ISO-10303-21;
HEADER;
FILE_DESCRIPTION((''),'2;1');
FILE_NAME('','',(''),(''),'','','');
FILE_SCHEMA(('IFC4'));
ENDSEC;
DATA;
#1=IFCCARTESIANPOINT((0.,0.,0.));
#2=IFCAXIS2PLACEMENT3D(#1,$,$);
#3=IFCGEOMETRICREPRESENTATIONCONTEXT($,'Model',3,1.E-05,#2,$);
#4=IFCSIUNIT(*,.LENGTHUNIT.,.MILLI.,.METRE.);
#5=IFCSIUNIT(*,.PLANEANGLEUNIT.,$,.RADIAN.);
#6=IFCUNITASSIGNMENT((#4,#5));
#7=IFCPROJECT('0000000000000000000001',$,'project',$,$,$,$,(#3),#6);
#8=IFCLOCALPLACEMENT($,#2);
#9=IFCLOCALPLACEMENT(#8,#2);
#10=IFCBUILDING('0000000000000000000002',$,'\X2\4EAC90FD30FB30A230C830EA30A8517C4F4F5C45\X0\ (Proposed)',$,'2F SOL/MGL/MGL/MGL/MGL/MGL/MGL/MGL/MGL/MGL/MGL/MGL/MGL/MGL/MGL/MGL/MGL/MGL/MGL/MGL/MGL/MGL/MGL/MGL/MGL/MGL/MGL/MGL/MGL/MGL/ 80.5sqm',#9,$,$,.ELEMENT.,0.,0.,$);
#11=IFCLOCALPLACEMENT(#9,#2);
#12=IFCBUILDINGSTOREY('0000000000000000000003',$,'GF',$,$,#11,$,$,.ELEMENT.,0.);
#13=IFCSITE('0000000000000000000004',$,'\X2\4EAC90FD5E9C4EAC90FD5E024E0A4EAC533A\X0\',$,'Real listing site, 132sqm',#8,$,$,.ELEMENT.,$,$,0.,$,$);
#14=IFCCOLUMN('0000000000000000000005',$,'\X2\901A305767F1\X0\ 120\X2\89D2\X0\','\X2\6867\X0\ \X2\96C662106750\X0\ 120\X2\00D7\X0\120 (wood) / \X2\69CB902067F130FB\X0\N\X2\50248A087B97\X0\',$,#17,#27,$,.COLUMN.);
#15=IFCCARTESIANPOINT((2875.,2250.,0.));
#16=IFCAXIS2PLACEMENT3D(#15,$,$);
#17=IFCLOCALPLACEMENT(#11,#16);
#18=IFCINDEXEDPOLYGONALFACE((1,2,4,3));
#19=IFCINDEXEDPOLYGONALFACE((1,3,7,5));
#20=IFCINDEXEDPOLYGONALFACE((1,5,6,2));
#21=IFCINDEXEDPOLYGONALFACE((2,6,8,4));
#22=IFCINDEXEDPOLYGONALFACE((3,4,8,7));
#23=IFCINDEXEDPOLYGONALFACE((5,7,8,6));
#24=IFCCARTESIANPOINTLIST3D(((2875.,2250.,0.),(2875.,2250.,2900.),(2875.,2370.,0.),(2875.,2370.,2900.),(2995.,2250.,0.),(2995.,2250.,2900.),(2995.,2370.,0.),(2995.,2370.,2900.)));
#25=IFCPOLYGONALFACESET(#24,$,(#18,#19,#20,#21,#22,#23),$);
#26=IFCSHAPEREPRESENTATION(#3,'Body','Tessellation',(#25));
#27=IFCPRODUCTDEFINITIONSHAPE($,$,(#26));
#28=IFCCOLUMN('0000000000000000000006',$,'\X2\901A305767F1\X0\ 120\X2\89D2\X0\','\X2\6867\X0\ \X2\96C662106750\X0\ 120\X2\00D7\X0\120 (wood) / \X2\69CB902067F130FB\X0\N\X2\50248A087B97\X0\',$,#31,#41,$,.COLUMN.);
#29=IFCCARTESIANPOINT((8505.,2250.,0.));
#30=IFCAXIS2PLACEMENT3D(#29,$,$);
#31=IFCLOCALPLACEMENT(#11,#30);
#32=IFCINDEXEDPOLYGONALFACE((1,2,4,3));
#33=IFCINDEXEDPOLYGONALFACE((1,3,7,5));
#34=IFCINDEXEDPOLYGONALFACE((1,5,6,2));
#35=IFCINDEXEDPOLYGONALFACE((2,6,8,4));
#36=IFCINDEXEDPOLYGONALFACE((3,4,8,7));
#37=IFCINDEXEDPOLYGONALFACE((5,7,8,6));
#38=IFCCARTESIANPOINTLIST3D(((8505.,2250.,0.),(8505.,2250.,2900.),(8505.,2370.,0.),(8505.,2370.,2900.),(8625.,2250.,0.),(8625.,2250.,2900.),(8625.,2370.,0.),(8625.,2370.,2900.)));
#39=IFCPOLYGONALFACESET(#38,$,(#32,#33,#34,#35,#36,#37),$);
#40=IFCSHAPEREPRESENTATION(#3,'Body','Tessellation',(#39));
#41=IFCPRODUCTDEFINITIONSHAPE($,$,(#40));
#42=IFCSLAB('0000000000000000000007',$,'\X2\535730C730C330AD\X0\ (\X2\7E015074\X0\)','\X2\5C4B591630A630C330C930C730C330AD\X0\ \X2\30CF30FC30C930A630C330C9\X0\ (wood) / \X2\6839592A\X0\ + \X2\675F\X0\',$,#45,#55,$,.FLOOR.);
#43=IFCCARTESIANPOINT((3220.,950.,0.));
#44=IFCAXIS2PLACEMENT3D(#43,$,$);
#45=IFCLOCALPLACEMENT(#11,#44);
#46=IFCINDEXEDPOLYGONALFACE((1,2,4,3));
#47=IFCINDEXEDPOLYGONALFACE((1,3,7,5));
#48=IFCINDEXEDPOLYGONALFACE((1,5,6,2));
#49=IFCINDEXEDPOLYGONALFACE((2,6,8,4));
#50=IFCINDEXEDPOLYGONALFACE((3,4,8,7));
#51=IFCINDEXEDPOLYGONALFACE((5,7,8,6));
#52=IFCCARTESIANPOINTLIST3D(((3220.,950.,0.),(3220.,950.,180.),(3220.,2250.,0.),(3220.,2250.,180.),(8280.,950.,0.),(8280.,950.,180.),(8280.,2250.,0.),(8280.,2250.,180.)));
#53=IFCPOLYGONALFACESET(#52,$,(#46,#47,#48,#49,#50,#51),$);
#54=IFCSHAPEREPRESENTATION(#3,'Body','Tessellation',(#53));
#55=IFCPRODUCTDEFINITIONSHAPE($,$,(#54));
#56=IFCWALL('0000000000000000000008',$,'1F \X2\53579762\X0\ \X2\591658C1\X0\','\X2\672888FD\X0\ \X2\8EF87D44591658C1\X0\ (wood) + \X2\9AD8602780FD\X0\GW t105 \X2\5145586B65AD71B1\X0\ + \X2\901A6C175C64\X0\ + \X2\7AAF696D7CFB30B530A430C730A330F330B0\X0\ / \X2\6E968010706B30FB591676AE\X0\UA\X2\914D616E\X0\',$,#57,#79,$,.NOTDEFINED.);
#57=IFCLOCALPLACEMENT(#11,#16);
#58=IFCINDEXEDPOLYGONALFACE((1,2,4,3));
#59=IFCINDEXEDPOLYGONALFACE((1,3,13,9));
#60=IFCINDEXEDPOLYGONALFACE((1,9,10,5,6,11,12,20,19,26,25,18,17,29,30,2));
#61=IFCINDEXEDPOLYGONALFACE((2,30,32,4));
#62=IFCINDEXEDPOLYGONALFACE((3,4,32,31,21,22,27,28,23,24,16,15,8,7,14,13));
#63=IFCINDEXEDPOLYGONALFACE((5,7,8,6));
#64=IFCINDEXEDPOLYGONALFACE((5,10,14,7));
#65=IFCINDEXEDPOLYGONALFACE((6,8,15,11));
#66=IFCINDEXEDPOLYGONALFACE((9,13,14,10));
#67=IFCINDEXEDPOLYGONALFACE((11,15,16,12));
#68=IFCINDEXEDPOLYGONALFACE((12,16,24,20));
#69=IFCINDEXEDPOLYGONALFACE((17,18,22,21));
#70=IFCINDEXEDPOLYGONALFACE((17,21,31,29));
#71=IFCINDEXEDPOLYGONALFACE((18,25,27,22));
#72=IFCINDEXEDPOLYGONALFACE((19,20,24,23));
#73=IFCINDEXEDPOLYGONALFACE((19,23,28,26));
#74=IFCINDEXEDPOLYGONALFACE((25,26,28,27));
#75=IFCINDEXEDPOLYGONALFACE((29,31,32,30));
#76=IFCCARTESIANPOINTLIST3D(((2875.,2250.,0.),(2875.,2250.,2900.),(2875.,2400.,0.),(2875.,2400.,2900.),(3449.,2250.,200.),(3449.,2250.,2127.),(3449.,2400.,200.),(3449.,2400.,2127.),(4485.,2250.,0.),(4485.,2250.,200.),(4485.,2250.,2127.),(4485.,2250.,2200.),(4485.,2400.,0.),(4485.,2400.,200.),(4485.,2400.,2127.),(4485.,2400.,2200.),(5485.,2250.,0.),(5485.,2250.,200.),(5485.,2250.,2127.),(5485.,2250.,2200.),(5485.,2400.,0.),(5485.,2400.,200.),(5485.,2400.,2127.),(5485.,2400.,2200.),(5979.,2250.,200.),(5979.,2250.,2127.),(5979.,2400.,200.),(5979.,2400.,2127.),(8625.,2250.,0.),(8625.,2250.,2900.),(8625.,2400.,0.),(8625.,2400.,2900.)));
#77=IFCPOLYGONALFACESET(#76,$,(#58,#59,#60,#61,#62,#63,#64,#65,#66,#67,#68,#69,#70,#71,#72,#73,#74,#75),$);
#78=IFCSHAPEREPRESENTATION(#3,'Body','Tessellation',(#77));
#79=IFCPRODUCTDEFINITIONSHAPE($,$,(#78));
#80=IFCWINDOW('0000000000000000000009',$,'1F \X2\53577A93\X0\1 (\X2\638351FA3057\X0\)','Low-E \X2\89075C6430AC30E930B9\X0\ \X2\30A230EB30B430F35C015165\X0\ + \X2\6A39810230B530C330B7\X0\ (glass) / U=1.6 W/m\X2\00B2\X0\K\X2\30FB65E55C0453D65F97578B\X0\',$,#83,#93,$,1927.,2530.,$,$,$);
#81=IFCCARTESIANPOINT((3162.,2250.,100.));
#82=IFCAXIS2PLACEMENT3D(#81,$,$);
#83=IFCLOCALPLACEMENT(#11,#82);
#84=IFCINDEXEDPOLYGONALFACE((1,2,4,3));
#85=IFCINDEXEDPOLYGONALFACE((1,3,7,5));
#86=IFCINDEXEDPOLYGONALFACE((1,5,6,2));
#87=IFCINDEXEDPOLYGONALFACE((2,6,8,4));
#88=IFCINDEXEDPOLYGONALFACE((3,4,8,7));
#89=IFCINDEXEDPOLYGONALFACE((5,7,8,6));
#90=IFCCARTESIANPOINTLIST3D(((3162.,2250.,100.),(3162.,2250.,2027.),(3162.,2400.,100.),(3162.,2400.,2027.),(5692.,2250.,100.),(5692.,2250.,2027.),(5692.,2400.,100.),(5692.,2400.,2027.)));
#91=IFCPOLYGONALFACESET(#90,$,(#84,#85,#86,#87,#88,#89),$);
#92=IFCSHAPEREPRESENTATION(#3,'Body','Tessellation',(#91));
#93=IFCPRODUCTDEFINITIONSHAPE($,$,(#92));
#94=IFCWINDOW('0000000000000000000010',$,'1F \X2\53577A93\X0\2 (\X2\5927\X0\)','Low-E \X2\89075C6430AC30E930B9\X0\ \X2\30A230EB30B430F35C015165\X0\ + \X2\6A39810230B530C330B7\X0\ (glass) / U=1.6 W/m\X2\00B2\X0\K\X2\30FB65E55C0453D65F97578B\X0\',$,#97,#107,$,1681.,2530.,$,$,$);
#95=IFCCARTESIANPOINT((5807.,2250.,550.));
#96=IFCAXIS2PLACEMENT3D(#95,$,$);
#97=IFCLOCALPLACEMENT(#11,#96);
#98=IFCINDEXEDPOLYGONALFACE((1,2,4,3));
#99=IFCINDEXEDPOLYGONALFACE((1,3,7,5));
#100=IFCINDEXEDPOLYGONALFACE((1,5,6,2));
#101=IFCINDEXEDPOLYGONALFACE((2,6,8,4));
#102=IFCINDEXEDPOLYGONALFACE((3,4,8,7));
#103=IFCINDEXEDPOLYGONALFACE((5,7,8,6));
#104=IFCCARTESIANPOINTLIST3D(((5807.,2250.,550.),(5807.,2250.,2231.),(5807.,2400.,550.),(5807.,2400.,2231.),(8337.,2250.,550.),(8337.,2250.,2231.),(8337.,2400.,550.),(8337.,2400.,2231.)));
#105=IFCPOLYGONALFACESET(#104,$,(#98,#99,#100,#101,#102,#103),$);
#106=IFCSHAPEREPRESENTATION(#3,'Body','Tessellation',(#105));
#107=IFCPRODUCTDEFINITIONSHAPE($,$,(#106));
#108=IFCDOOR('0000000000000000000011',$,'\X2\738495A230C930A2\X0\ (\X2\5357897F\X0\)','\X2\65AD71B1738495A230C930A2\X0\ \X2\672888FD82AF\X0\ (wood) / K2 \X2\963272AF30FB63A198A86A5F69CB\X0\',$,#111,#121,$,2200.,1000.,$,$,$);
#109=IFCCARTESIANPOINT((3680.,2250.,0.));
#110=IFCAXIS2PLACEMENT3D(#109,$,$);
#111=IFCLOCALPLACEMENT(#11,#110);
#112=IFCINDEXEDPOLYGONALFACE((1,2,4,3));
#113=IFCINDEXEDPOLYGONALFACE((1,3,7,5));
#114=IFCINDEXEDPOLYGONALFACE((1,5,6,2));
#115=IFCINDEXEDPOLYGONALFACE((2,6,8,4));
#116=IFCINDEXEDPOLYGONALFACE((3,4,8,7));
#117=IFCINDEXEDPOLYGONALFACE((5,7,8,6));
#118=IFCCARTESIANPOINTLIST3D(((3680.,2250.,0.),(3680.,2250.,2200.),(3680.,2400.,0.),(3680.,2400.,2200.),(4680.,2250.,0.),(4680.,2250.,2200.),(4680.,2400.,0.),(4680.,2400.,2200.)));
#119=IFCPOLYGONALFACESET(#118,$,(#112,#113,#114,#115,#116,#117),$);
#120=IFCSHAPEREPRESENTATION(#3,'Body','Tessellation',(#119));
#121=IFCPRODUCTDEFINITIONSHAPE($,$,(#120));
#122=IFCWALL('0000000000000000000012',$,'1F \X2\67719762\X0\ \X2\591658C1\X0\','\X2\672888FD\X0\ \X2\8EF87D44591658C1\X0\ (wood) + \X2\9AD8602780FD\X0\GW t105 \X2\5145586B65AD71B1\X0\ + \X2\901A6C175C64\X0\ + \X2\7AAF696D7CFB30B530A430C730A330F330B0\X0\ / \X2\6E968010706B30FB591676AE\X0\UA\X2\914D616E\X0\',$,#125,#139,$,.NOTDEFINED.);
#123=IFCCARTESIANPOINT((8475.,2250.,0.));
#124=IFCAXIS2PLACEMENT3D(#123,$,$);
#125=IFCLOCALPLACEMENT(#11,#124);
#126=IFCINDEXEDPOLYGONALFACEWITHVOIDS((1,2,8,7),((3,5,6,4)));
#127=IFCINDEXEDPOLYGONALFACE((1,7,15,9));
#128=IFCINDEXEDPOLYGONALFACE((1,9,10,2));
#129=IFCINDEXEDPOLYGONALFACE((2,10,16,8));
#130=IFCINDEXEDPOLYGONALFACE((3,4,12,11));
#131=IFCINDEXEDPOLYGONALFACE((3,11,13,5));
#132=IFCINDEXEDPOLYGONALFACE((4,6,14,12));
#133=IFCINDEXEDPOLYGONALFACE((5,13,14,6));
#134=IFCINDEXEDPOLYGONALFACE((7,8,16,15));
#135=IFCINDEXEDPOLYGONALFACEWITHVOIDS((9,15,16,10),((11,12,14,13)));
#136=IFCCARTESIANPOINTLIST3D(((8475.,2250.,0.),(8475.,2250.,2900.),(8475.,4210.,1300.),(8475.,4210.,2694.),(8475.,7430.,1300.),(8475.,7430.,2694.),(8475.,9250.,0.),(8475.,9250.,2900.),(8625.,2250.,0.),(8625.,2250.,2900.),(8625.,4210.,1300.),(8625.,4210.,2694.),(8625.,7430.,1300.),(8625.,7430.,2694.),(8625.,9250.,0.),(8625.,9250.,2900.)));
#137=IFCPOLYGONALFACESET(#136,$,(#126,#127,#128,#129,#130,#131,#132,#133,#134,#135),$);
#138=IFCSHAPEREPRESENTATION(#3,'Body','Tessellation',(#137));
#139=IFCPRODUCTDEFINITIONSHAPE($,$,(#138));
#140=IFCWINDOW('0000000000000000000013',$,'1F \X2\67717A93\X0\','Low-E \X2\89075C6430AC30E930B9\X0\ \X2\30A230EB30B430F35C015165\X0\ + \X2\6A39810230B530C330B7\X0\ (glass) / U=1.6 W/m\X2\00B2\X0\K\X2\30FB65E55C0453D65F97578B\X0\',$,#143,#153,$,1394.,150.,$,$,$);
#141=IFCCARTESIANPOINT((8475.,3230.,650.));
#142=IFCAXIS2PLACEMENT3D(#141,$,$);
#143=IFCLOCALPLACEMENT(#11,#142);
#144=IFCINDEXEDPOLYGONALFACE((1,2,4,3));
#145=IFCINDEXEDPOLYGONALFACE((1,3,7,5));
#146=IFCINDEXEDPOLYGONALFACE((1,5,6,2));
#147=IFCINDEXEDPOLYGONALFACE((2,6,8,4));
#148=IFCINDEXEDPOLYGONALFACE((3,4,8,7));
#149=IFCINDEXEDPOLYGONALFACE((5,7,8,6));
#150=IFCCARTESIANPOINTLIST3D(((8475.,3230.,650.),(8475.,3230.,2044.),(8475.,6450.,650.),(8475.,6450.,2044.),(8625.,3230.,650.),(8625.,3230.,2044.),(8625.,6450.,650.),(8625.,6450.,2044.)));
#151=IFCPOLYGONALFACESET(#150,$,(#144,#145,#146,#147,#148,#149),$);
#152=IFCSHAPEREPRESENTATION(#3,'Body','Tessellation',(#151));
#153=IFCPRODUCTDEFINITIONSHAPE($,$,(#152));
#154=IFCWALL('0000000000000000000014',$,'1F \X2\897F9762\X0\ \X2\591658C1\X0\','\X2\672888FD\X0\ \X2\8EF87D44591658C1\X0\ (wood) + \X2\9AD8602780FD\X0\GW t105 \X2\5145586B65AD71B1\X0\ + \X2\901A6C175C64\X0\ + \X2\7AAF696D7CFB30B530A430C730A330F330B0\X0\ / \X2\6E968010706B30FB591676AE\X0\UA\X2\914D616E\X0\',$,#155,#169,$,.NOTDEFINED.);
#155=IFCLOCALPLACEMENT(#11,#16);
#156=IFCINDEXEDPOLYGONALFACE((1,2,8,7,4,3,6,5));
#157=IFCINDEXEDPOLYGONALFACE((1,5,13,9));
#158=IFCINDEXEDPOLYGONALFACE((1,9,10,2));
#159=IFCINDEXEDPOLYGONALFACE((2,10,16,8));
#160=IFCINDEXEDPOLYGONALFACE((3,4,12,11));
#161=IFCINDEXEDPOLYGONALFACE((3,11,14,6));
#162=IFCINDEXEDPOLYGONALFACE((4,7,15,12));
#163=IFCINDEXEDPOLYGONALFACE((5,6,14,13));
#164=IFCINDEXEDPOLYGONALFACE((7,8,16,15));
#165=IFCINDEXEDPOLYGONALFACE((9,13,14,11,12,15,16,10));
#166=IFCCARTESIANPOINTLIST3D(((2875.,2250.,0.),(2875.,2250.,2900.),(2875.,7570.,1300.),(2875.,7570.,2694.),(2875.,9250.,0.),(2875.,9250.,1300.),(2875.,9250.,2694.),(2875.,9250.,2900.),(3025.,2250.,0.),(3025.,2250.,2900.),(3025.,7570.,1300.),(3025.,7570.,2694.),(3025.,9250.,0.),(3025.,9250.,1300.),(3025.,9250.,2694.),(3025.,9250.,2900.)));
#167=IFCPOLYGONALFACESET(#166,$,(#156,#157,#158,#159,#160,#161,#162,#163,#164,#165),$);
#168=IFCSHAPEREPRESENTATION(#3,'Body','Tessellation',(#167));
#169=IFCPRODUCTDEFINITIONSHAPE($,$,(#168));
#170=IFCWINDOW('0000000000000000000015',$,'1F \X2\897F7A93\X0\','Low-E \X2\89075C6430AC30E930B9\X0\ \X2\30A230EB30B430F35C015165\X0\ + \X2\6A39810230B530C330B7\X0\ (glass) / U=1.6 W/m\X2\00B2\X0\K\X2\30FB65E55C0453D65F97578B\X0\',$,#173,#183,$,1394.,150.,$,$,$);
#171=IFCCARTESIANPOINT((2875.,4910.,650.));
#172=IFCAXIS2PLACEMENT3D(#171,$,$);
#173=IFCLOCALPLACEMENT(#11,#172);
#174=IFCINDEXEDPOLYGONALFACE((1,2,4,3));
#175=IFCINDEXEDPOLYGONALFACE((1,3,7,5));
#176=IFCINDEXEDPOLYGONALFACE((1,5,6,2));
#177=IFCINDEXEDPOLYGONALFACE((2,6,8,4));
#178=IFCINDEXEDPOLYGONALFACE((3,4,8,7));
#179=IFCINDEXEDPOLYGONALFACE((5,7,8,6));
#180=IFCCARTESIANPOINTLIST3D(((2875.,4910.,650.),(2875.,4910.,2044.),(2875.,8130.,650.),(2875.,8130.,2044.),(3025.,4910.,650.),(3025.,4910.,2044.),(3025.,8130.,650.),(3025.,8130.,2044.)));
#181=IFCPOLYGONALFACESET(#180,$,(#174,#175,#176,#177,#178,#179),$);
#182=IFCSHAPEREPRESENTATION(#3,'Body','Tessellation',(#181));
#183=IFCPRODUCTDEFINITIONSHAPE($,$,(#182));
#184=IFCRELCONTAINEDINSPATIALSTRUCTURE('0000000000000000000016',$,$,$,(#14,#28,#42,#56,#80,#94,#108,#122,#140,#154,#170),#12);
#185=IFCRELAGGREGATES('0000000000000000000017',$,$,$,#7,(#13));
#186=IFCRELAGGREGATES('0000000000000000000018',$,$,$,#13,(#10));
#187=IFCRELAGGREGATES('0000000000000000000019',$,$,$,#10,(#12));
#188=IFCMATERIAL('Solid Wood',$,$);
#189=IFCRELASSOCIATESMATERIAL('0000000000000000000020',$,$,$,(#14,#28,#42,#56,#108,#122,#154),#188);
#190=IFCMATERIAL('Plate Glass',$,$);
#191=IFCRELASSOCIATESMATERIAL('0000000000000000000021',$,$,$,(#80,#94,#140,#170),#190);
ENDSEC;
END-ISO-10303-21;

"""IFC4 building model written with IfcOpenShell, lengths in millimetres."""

from ifc_helpers import new_model, si_unit, frame, frame_2d, origin, place, context, project, spatial, rectangle, extrude, material, element, fill, save


model = new_model("IFC4")

# Units and contexts
model_context = context("Model", 3, precision=1e-05, world=origin())
ifc_project = project(units=[si_unit("LENGTHUNIT", "METRE", prefix="MILLI"), si_unit("PLANEANGLEUNIT", "RADIAN")], contexts=[model_context])

# Site, building, storey
site_placement = place(None, origin())
site = spatial("IfcSite", under=ifc_project, at=site_placement, Name="京都府京都市上京区", ObjectType="Real listing site, 132sqm", CompositionType="ELEMENT", RefElevation=0.0)
building_placement = place(site_placement, origin())
building = spatial("IfcBuilding", under=site, at=building_placement, Name="京都・アトリエ兼住居 (Proposed)", ObjectType="2F SOL/MGL/MGL/MGL/MGL/MGL/MGL/MGL/MGL/MGL/MGL/MGL/MGL/MGL/MGL/MGL/MGL/MGL/MGL/MGL/MGL/MGL/MGL/MGL/MGL/MGL/MGL/MGL/MGL/MGL/ 80.5sqm", CompositionType="ELEMENT", ElevationOfRefHeight=0.0, ElevationOfTerrain=0.0)
storey_placement = place(building_placement, origin())
storey = spatial("IfcBuildingStorey", under=building, at=storey_placement, Name="GF", CompositionType="ELEMENT", Elevation=0.0)

# Columns
ifc_material_1 = material(Name="Solid Wood")
column_1_placement = place(storey_placement, frame((2875.0, 2250.0, 0.0)))
element("IfcColumn", 1, at=column_1_placement, inside=storey, material=ifc_material_1, Name="通し柱 120角", Description="桧 集成材 120×120 (wood) / 構造柱・N値計算", PredefinedType="COLUMN", context=model_context, shape_type="SweptSolid", body=[
    extrude(rectangle(XDim=120.0, YDim=120.0, at=frame_2d((60.0, 60.0))), frame((2875.0, 2250.0, 0.0)), (0.0, 0.0, 1.0), 2900.0),
])
column_2_placement = place(storey_placement, frame((8505.0, 2250.0, 0.0)))
element("IfcColumn", 2, at=column_2_placement, inside=storey, material=ifc_material_1, Name="通し柱 120角", Description="桧 集成材 120×120 (wood) / 構造柱・N値計算", PredefinedType="COLUMN", context=model_context, shape_type="SweptSolid", body=[
    extrude(rectangle(XDim=120.0, YDim=120.0, at=frame_2d((60.0, 60.0))), frame((8505.0, 2250.0, 0.0)), (0.0, 0.0, 1.0), 2900.0),
])

# Slab
slab_1_placement = place(storey_placement, frame((3220.0, 950.0, 0.0)))
element("IfcSlab", 3, at=slab_1_placement, inside=storey, material=ifc_material_1, Name="南デッキ (縁側)", Description="屋外ウッドデッキ ハードウッド (wood) / 根太 + 束", PredefinedType="FLOOR", context=model_context, shape_type="SweptSolid", body=[
    extrude(rectangle(XDim=5060.0, YDim=1300.0, at=frame_2d((2530.0, 650.0))), frame((3220.0, 950.0, 0.0)), (0.0, 0.0, 1.0), 180.0),
])

# Wall, openings, windows, door
wall_1_placement = place(storey_placement, frame((2875.0, 2250.0, 0.0)))
wall_1 = element("IfcWall", 4, at=wall_1_placement, inside=storey, material=ifc_material_1, Name="1F 南面 外壁", Description="木製 軸組外壁 (wood) + 高性能GW t105 充填断熱 + 通気層 + 窯業系サイディング / 準耐火・外皮UA配慮", PredefinedType="NOTDEFINED", context=model_context, shape_type="SweptSolid", body=[
    extrude(rectangle(XDim=5750.0, YDim=150.0, at=frame_2d((2875.0, 75.0))), frame((2875.0, 2250.0, 0.0)), (0.0, 0.0, 1.0), 2900.0),
])
opening_1_placement = place(storey_placement, frame((3162.0, 2250.0, 100.0)))
opening_1 = element("IfcOpeningElement", 5, at=opening_1_placement, cuts=wall_1, PredefinedType="NOTDEFINED", context=model_context, shape_type="SweptSolid", body=[
    extrude(rectangle(XDim=2530.0, YDim=150.0, at=frame_2d((1265.0, 75.0))), frame((3162.0, 2250.0, 100.0)), (0.0, 0.0, 1.0), 1927.0),
])
opening_2_placement = place(storey_placement, frame((5807.0, 2250.0, 550.0)))
opening_2 = element("IfcOpeningElement", 6, at=opening_2_placement, cuts=wall_1, PredefinedType="NOTDEFINED", context=model_context, shape_type="SweptSolid", body=[
    extrude(rectangle(XDim=2530.0, YDim=150.0, at=frame_2d((1265.0, 75.0))), frame((5807.0, 2250.0, 550.0)), (0.0, 0.0, 1.0), 1681.0),
])
opening_3_placement = place(storey_placement, frame((3680.0, 2250.0, 0.0)))
opening_3 = element("IfcOpeningElement", 7, at=opening_3_placement, cuts=wall_1, PredefinedType="NOTDEFINED", context=model_context, shape_type="SweptSolid", body=[
    extrude(rectangle(XDim=1000.0, YDim=150.0, at=frame_2d((500.0, 75.0))), frame((3680.0, 2250.0, 0.0)), (0.0, 0.0, 1.0), 2200.0),
])
ifc_material_2 = material(Name="Plate Glass")
window_1_placement = place(storey_placement, frame((3162.0, 2250.0, 100.0)))
window_1 = element("IfcWindow", 8, at=window_1_placement, inside=storey, material=ifc_material_2, Name="1F 南窓1 (掃出し)", Description="Low-E 複層ガラス アルゴン封入 + 樹脂サッシ (glass) / U=1.6 W/m²K・日射取得型", OverallHeight=1927.0, OverallWidth=2530.0, context=model_context, shape_type="SweptSolid", body=[
    extrude(rectangle(XDim=2530.0, YDim=150.0, at=frame_2d((1265.0, 75.0))), frame((3162.0, 2250.0, 100.0)), (0.0, 0.0, 1.0), 1927.0),
])
fill(opening_1, window_1)
window_2_placement = place(storey_placement, frame((5807.0, 2250.0, 550.0)))
window_2 = element("IfcWindow", 9, at=window_2_placement, inside=storey, material=ifc_material_2, Name="1F 南窓2 (大)", Description="Low-E 複層ガラス アルゴン封入 + 樹脂サッシ (glass) / U=1.6 W/m²K・日射取得型", OverallHeight=1681.0, OverallWidth=2530.0, context=model_context, shape_type="SweptSolid", body=[
    extrude(rectangle(XDim=2530.0, YDim=150.0, at=frame_2d((1265.0, 75.0))), frame((5807.0, 2250.0, 550.0)), (0.0, 0.0, 1.0), 1681.0),
])
fill(opening_2, window_2)
door_placement = place(storey_placement, frame((3680.0, 2250.0, 0.0)))
door = element("IfcDoor", 10, at=door_placement, inside=storey, material=ifc_material_1, Name="玄関ドア (南西)", Description="断熱玄関ドア 木製芯 (wood) / K2 防犯・採風機構", OverallHeight=2200.0, OverallWidth=1000.0, context=model_context, shape_type="SweptSolid", body=[
    extrude(rectangle(XDim=1000.0, YDim=150.0, at=frame_2d((500.0, 75.0))), frame((3680.0, 2250.0, 0.0)), (0.0, 0.0, 1.0), 2200.0),
])
fill(opening_3, door)

# Walls, openings, windows
wall_2_placement = place(storey_placement, frame((8475.0, 2250.0, 0.0)))
wall_2 = element("IfcWall", 11, at=wall_2_placement, inside=storey, material=ifc_material_1, Name="1F 東面 外壁", Description="木製 軸組外壁 (wood) + 高性能GW t105 充填断熱 + 通気層 + 窯業系サイディング / 準耐火・外皮UA配慮", PredefinedType="NOTDEFINED", context=model_context, shape_type="SweptSolid", body=[
    extrude(rectangle(XDim=150.0, YDim=7000.0, at=frame_2d((75.0, 3500.0))), frame((8475.0, 2250.0, 0.0)), (0.0, 0.0, 1.0), 2900.0),
])
opening_4_placement = place(storey_placement, frame((8475.0, 3230.0, 650.0)))
opening_4 = element("IfcOpeningElement", 12, at=opening_4_placement, cuts=wall_2, PredefinedType="NOTDEFINED", context=model_context, shape_type="SweptSolid", body=[
    extrude(rectangle(XDim=150.0, YDim=3220.0, at=frame_2d((75.0, 1610.0))), frame((8475.0, 3230.0, 650.0)), (0.0, 0.0, 1.0), 1394.0),
])
window_3_placement = place(storey_placement, frame((8475.0, 3230.0, 650.0)))
window_3 = element("IfcWindow", 13, at=window_3_placement, inside=storey, material=ifc_material_2, Name="1F 東窓", Description="Low-E 複層ガラス アルゴン封入 + 樹脂サッシ (glass) / U=1.6 W/m²K・日射取得型", OverallHeight=1394.0, OverallWidth=150.0, context=model_context, shape_type="SweptSolid", body=[
    extrude(rectangle(XDim=150.0, YDim=3220.0, at=frame_2d((75.0, 1610.0))), frame((8475.0, 3230.0, 650.0)), (0.0, 0.0, 1.0), 1394.0),
])
fill(opening_4, window_3)
wall_3_placement = place(storey_placement, frame((2875.0, 2250.0, 0.0)))
wall_3 = element("IfcWall", 14, at=wall_3_placement, inside=storey, material=ifc_material_1, Name="1F 西面 外壁", Description="木製 軸組外壁 (wood) + 高性能GW t105 充填断熱 + 通気層 + 窯業系サイディング / 準耐火・外皮UA配慮", PredefinedType="NOTDEFINED", context=model_context, shape_type="SweptSolid", body=[
    extrude(rectangle(XDim=150.0, YDim=7000.0, at=frame_2d((75.0, 3500.0))), frame((2875.0, 2250.0, 0.0)), (0.0, 0.0, 1.0), 2900.0),
])
opening_5_placement = place(storey_placement, frame((2875.0, 4910.0, 650.0)))
opening_5 = element("IfcOpeningElement", 15, at=opening_5_placement, cuts=wall_3, PredefinedType="NOTDEFINED", context=model_context, shape_type="SweptSolid", body=[
    extrude(rectangle(XDim=150.0, YDim=3220.0, at=frame_2d((75.0, 1610.0))), frame((2875.0, 4910.0, 650.0)), (0.0, 0.0, 1.0), 1394.0),
])
window_4_placement = place(storey_placement, frame((2875.0, 4910.0, 650.0)))
window_4 = element("IfcWindow", 16, at=window_4_placement, inside=storey, material=ifc_material_2, Name="1F 西窓", Description="Low-E 複層ガラス アルゴン封入 + 樹脂サッシ (glass) / U=1.6 W/m²K・日射取得型", OverallHeight=1394.0, OverallWidth=150.0, context=model_context, shape_type="SweptSolid", body=[
    extrude(rectangle(XDim=150.0, YDim=3220.0, at=frame_2d((75.0, 1610.0))), frame((2875.0, 4910.0, 650.0)), (0.0, 0.0, 1.0), 1394.0),
])
fill(opening_5, window_4)

save(model, "model.ifc")
